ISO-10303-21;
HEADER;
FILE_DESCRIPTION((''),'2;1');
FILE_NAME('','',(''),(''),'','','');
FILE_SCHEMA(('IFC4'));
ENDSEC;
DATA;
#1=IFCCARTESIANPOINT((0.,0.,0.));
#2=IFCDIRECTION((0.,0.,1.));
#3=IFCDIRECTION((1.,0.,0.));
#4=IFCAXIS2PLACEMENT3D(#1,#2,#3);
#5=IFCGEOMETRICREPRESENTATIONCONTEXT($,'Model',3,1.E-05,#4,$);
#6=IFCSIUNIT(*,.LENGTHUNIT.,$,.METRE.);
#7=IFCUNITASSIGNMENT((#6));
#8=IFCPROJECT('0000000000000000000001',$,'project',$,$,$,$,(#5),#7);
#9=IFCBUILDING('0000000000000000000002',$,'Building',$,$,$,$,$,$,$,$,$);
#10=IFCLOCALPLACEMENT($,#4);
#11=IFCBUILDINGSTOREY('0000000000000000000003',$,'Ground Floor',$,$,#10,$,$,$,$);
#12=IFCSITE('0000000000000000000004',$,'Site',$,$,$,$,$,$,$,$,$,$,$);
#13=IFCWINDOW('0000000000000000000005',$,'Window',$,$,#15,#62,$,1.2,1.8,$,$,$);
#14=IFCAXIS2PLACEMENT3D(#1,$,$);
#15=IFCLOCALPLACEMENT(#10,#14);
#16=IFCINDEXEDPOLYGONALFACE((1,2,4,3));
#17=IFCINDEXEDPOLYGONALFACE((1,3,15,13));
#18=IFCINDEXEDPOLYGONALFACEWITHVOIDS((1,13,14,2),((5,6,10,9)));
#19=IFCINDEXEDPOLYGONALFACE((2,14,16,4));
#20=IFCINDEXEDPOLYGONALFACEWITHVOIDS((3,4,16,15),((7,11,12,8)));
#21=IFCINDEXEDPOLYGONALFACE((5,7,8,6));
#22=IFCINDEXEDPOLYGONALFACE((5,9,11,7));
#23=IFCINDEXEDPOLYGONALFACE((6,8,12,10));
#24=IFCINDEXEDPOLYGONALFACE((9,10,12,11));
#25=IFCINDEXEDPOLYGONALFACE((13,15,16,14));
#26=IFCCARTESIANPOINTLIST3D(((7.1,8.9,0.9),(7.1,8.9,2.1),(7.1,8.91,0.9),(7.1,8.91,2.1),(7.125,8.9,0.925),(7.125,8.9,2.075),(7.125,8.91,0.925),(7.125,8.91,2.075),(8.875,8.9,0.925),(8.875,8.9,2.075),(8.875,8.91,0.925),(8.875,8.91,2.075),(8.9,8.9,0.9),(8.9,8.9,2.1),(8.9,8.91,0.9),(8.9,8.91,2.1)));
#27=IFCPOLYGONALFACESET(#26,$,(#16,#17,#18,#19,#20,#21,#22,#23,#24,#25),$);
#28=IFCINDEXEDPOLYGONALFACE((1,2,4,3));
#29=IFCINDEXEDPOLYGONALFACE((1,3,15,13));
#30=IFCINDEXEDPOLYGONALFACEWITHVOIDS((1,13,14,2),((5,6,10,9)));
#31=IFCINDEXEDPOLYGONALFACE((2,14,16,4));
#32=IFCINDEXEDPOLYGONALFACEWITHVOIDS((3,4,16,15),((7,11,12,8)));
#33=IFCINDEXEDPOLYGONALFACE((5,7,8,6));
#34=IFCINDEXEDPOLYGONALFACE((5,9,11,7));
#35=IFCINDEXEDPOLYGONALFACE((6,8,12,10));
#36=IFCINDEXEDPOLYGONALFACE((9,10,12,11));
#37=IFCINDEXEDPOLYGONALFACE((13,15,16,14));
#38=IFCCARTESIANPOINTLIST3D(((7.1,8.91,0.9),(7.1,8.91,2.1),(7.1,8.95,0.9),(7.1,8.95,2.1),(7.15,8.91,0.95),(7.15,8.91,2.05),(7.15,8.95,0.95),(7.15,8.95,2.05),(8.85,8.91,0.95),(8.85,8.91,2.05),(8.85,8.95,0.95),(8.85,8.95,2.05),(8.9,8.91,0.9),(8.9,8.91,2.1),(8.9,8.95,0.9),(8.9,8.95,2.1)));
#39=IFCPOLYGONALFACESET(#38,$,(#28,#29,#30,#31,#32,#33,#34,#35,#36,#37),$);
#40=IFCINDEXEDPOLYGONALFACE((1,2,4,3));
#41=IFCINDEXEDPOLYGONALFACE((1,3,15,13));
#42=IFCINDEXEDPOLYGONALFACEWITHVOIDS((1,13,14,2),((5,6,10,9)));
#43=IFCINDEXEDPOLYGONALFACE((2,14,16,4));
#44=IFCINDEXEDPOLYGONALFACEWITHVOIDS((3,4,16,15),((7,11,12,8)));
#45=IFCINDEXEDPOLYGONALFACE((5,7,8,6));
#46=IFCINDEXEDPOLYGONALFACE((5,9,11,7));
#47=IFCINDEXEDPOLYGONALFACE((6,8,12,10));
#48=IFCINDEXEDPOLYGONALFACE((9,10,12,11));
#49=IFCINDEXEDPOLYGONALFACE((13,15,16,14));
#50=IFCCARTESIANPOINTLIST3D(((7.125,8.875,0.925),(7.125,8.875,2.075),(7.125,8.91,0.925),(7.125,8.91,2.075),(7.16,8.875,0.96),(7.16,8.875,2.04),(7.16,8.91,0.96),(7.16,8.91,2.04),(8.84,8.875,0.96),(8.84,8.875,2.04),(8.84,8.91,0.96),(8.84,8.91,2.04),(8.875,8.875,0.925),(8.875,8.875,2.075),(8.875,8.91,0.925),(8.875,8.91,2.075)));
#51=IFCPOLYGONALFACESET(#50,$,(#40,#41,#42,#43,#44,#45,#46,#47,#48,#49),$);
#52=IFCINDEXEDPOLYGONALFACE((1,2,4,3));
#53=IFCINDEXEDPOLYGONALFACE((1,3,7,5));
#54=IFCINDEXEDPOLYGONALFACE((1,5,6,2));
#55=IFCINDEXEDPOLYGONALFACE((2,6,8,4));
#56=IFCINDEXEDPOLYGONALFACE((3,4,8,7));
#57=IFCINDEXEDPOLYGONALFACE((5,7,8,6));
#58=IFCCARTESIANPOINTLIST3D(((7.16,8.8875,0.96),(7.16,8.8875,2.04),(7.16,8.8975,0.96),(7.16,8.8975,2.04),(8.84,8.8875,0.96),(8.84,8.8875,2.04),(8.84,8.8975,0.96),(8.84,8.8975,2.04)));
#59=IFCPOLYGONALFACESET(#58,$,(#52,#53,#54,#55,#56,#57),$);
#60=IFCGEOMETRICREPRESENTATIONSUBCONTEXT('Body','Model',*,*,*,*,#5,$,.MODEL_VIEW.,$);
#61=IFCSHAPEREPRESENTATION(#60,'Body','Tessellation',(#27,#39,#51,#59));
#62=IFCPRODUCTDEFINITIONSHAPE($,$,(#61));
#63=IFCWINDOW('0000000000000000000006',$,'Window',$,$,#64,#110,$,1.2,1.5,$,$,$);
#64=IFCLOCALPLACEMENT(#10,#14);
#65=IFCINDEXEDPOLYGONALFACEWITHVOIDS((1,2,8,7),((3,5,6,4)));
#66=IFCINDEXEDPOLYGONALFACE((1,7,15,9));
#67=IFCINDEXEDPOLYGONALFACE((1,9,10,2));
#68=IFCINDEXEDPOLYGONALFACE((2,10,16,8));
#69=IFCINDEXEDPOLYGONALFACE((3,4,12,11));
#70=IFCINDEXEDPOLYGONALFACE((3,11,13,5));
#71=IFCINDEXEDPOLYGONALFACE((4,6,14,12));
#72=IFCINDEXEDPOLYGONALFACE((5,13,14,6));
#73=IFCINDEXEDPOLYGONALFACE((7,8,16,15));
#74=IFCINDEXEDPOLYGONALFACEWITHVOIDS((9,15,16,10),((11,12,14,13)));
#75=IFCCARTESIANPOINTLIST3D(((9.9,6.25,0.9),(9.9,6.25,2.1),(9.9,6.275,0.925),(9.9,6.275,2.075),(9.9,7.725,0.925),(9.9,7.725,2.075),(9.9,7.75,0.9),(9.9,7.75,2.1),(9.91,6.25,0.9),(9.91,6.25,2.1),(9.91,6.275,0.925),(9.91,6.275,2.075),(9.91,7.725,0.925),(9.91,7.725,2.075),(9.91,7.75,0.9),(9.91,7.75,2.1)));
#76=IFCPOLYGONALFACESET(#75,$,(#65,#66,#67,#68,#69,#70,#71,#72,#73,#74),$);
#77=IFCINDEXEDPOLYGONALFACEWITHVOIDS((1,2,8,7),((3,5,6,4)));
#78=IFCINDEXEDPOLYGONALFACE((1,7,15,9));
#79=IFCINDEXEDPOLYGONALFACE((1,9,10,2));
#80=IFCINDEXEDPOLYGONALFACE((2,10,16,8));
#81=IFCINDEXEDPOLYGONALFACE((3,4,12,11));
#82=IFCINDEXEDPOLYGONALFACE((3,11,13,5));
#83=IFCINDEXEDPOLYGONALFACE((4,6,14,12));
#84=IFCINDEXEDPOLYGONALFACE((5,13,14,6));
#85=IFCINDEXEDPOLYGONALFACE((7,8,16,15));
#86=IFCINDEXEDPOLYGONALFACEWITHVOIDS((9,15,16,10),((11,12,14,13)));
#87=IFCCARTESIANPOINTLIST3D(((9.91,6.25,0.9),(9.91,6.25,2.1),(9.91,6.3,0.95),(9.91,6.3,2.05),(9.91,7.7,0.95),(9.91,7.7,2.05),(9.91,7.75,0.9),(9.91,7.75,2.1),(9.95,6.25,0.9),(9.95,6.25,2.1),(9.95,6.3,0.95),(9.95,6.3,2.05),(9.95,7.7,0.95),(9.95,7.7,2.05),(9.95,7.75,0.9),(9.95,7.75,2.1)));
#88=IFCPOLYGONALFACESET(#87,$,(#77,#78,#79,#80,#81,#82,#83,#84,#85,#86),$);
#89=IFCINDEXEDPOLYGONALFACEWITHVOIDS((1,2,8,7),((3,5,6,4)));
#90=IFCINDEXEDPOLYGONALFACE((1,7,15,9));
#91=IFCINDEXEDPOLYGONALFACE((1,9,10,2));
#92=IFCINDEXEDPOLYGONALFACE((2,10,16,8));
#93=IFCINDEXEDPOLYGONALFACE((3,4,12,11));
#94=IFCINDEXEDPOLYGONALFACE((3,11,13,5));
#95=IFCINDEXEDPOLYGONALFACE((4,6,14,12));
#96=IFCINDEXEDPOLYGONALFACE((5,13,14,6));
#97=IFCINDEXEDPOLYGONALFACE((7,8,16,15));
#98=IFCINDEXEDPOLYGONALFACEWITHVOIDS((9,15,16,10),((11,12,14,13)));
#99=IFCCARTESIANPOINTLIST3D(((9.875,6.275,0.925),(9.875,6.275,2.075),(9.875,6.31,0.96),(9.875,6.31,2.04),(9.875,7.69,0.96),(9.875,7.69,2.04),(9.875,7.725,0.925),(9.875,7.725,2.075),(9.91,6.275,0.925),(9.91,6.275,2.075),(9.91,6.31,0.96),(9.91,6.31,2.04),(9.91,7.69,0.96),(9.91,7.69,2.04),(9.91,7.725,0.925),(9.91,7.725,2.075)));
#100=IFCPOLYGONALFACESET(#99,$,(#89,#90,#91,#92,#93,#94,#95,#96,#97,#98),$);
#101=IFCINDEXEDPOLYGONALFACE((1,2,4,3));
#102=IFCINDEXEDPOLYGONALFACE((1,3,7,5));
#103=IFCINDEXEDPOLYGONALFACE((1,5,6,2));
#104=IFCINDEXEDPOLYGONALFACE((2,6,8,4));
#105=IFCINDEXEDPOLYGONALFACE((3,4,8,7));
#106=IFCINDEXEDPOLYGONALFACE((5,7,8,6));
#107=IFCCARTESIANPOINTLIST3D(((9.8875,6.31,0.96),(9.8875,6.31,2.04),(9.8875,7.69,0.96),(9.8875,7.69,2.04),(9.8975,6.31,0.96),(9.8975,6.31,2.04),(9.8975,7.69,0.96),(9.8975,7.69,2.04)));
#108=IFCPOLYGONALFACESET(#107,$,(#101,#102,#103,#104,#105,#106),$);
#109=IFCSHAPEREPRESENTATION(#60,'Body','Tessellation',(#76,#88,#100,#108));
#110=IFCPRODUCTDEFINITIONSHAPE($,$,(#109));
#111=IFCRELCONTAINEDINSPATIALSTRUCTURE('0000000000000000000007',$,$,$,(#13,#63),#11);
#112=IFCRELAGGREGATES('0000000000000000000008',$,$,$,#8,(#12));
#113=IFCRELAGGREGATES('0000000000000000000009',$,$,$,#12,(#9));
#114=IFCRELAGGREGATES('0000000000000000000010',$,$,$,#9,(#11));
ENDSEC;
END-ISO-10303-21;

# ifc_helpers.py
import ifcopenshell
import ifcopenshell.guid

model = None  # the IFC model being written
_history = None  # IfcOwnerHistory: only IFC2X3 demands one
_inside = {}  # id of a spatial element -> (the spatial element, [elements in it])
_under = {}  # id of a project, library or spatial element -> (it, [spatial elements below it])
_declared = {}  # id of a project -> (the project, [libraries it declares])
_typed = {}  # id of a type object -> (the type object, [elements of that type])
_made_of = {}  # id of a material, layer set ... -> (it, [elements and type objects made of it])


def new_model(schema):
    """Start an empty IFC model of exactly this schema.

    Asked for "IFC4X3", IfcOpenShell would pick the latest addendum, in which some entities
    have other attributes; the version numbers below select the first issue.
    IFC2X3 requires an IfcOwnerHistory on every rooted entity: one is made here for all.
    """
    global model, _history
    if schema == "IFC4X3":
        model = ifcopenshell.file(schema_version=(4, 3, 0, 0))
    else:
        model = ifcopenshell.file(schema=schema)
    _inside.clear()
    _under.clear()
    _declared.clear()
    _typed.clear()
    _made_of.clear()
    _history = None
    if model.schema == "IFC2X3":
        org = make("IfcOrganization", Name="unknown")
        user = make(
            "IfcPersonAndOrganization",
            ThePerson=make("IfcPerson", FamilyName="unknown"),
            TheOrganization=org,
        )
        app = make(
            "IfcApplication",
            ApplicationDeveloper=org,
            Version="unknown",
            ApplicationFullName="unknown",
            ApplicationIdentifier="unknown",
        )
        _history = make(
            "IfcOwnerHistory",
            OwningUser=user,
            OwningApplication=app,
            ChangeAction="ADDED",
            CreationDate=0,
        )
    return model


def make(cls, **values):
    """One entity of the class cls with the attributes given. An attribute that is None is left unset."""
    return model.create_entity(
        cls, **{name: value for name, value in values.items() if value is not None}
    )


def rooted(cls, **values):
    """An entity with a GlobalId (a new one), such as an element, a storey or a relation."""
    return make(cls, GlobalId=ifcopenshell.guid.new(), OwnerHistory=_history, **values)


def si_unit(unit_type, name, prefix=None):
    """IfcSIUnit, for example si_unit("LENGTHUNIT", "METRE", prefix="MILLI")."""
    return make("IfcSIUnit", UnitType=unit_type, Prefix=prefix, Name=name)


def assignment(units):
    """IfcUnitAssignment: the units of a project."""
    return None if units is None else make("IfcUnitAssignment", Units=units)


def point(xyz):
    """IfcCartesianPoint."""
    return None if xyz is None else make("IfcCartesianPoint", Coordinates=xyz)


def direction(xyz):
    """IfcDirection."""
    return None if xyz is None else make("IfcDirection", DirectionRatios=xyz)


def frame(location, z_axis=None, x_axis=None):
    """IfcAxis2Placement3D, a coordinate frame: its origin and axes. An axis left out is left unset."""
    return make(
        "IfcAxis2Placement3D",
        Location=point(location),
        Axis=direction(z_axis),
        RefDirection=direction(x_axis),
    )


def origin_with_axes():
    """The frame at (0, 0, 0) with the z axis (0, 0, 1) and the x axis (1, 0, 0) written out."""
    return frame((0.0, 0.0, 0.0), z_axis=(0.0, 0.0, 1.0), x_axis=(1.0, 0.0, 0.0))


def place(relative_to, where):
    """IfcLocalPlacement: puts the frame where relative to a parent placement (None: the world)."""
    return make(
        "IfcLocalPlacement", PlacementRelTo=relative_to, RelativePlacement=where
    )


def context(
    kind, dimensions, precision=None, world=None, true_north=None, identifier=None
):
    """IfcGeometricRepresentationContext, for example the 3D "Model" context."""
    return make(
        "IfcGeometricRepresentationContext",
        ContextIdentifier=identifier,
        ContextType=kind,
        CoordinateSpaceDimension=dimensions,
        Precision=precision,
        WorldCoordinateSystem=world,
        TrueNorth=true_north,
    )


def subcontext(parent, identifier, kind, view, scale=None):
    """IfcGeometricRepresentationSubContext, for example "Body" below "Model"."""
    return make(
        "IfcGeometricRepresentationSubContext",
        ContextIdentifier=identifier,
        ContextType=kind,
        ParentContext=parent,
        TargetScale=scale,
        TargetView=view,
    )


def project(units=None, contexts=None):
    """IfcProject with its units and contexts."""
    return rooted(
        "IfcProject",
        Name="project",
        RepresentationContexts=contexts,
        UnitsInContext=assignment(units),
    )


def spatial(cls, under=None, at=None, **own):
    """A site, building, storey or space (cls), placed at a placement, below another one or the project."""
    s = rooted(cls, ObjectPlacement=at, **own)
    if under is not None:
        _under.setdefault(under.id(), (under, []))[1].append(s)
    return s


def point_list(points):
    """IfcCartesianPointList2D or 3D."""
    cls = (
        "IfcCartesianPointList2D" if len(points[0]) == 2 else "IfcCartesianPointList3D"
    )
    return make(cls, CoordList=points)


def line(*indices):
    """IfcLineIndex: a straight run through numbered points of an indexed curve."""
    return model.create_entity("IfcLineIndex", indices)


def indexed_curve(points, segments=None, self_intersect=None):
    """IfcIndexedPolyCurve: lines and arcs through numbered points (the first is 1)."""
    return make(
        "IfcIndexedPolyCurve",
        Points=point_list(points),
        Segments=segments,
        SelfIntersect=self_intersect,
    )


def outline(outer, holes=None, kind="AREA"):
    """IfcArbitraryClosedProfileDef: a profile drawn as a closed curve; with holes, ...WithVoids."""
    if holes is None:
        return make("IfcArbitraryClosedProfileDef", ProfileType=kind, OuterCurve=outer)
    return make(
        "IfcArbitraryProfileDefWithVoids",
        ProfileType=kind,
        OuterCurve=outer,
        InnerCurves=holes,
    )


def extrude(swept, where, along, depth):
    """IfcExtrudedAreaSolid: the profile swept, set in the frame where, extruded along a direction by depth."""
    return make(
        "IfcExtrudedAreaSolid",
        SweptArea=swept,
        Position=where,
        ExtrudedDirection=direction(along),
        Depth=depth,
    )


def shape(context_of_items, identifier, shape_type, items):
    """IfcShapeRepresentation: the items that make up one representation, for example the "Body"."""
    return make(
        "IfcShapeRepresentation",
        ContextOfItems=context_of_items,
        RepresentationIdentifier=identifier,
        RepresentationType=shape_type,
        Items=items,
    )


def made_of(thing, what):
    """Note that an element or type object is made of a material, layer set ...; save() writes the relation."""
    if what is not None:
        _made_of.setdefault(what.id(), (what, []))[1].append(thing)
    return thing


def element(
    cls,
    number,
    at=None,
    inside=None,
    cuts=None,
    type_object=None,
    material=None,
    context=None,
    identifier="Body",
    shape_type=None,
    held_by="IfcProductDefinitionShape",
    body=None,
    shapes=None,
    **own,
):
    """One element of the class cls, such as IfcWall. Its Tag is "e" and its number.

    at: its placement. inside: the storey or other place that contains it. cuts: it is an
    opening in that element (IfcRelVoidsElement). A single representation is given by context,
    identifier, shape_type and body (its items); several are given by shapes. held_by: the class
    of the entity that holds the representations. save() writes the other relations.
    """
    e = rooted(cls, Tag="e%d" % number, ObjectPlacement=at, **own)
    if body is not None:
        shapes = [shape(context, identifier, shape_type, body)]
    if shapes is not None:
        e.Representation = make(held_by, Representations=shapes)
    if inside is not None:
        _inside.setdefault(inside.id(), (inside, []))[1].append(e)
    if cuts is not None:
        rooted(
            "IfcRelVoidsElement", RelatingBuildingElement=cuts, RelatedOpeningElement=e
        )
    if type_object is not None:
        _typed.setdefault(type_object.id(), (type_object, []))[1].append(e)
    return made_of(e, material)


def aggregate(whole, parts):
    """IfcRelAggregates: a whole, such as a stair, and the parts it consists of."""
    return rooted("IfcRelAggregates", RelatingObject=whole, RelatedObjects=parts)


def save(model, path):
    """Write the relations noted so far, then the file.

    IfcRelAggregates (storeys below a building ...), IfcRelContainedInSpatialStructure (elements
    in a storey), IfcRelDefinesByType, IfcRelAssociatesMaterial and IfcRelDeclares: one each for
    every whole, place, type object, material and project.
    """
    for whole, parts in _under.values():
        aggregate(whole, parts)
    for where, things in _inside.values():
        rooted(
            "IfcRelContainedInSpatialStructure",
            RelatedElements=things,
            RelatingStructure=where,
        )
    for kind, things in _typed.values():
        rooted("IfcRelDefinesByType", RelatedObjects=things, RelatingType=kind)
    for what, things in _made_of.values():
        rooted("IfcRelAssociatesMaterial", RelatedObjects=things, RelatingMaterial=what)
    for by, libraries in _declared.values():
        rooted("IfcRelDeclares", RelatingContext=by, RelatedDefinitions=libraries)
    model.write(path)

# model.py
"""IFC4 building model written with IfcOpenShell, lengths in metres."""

from ifc_helpers import new_model, si_unit, frame, origin_with_axes, place, context, subcontext, project, spatial, line, indexed_curve, outline, extrude, element, save


model = new_model("IFC4")

# Units and contexts
model_context = context("Model", 3, precision=1e-05, world=origin_with_axes())
body_context = subcontext(model_context, "Body", "Model", "MODEL_VIEW")
ifc_project = project(units=[si_unit("LENGTHUNIT", "METRE")], contexts=[model_context])

# Site, building, storey
site = spatial("IfcSite", under=ifc_project, Name="Site")
building = spatial("IfcBuilding", under=site, Name="Building")
storey_placement = place(None, origin_with_axes())
storey = spatial("IfcBuildingStorey", under=building, at=storey_placement, Name="Ground Floor")

# Windows
for number, where, z_axis, x_axis, name in (
    (1, (8.9, 9.0, 0.9), (0.0, 0.0, 1.0), (-1.0, 0.0, 0.0), "Window"),
):
    element("IfcWindow", number, at=place(storey_placement, frame(where, z_axis=z_axis, x_axis=x_axis)), inside=storey, Name=name, OverallHeight=1.2, OverallWidth=1.8, context=body_context, shape_type="SweptSolid", body=[
        extrude(outline(indexed_curve([(0.0, 0.0), (1.8, 0.0), (1.8, 1.2), (0.0, 1.2)], segments=[line(1, 2, 3, 4, 1)]), holes=[indexed_curve([(0.025, 0.025), (1.775, 0.025), (1.775, 1.175), (0.025, 1.175)], segments=[line(1, 2, 3, 4, 1)])]), frame((0.0, 0.09, 0.0), z_axis=(0.0, -1.0, 0.0), x_axis=(1.0, 0.0, 0.0)), (0.0, 0.0, -1.0), 0.01),
        extrude(outline(indexed_curve([(0.0, 0.0), (1.8, 0.0), (1.8, 1.2), (0.0, 1.2)], segments=[line(1, 2, 3, 4, 1)]), holes=[indexed_curve([(0.05, 0.05), (1.75, 0.05), (1.75, 1.15), (0.05, 1.15)], segments=[line(1, 2, 3, 4, 1)])]), frame((0.0, 0.05, 0.0), z_axis=(0.0, -1.0, 0.0), x_axis=(1.0, 0.0, 0.0)), (0.0, 0.0, -1.0), 0.04),
        extrude(outline(indexed_curve([(0.0, 0.0), (1.75, 0.0), (1.75, 1.15), (0.0, 1.15)], segments=[line(1, 2, 3, 4, 1)]), holes=[indexed_curve([(0.035, 0.035), (1.715, 0.035), (1.715, 1.115), (0.035, 1.115)], segments=[line(1, 2, 3, 4, 1)])]), frame((0.025, 0.09, 0.025), z_axis=(0.0, -1.0, 0.0), x_axis=(1.0, 0.0, 0.0)), (0.0, 0.0, -1.0), 0.035),
        extrude(outline(indexed_curve([(0.035, 0.035), (1.715, 0.035), (1.715, 1.115), (0.035, 1.115)], segments=[line(1, 2, 3, 4, 1)])), frame((0.025, 0.1025, 0.025), z_axis=(0.0, -1.0, 0.0), x_axis=(1.0, 0.0, 0.0)), (0.0, 0.0, -1.0), 0.01),
    ])
window_1_placement = place(storey_placement, frame((10.0, 6.25, 0.9), z_axis=(0.0, 0.0, 1.0), x_axis=(0.0, 1.0, 0.0)))
element("IfcWindow", 2, at=window_1_placement, inside=storey, Name="Window", OverallHeight=1.2, OverallWidth=1.5, context=body_context, shape_type="SweptSolid", body=[
    extrude(outline(indexed_curve([(0.0, 0.0), (1.5, 0.0), (1.5, 1.2), (0.0, 1.2)], segments=[line(1, 2, 3, 4, 1)]), holes=[indexed_curve([(0.025, 0.025), (1.475, 0.025), (1.475, 1.175), (0.025, 1.175)], segments=[line(1, 2, 3, 4, 1)])]), frame((0.0, 0.09, 0.0), z_axis=(0.0, -1.0, 0.0), x_axis=(1.0, 0.0, 0.0)), (0.0, 0.0, -1.0), 0.01),
    extrude(outline(indexed_curve([(0.0, 0.0), (1.5, 0.0), (1.5, 1.2), (0.0, 1.2)], segments=[line(1, 2, 3, 4, 1)]), holes=[indexed_curve([(0.05, 0.05), (1.45, 0.05), (1.45, 1.15), (0.05, 1.15)], segments=[line(1, 2, 3, 4, 1)])]), frame((0.0, 0.05, 0.0), z_axis=(0.0, -1.0, 0.0), x_axis=(1.0, 0.0, 0.0)), (0.0, 0.0, -1.0), 0.04),
    extrude(outline(indexed_curve([(0.0, 0.0), (1.45, 0.0), (1.45, 1.15), (0.0, 1.15)], segments=[line(1, 2, 3, 4, 1)]), holes=[indexed_curve([(0.035, 0.035), (1.415, 0.035), (1.415, 1.115), (0.035, 1.115)], segments=[line(1, 2, 3, 4, 1)])]), frame((0.025, 0.09, 0.025), z_axis=(0.0, -1.0, 0.0), x_axis=(1.0, 0.0, 0.0)), (0.0, 0.0, -1.0), 0.035),
    extrude(outline(indexed_curve([(0.035, 0.035), (1.415, 0.035), (1.415, 1.115), (0.035, 1.115)], segments=[line(1, 2, 3, 4, 1)])), frame((0.025, 0.1025, 0.025), z_axis=(0.0, -1.0, 0.0), x_axis=(1.0, 0.0, 0.0)), (0.0, 0.0, -1.0), 0.01),
])

save(model, "model.ifc")
